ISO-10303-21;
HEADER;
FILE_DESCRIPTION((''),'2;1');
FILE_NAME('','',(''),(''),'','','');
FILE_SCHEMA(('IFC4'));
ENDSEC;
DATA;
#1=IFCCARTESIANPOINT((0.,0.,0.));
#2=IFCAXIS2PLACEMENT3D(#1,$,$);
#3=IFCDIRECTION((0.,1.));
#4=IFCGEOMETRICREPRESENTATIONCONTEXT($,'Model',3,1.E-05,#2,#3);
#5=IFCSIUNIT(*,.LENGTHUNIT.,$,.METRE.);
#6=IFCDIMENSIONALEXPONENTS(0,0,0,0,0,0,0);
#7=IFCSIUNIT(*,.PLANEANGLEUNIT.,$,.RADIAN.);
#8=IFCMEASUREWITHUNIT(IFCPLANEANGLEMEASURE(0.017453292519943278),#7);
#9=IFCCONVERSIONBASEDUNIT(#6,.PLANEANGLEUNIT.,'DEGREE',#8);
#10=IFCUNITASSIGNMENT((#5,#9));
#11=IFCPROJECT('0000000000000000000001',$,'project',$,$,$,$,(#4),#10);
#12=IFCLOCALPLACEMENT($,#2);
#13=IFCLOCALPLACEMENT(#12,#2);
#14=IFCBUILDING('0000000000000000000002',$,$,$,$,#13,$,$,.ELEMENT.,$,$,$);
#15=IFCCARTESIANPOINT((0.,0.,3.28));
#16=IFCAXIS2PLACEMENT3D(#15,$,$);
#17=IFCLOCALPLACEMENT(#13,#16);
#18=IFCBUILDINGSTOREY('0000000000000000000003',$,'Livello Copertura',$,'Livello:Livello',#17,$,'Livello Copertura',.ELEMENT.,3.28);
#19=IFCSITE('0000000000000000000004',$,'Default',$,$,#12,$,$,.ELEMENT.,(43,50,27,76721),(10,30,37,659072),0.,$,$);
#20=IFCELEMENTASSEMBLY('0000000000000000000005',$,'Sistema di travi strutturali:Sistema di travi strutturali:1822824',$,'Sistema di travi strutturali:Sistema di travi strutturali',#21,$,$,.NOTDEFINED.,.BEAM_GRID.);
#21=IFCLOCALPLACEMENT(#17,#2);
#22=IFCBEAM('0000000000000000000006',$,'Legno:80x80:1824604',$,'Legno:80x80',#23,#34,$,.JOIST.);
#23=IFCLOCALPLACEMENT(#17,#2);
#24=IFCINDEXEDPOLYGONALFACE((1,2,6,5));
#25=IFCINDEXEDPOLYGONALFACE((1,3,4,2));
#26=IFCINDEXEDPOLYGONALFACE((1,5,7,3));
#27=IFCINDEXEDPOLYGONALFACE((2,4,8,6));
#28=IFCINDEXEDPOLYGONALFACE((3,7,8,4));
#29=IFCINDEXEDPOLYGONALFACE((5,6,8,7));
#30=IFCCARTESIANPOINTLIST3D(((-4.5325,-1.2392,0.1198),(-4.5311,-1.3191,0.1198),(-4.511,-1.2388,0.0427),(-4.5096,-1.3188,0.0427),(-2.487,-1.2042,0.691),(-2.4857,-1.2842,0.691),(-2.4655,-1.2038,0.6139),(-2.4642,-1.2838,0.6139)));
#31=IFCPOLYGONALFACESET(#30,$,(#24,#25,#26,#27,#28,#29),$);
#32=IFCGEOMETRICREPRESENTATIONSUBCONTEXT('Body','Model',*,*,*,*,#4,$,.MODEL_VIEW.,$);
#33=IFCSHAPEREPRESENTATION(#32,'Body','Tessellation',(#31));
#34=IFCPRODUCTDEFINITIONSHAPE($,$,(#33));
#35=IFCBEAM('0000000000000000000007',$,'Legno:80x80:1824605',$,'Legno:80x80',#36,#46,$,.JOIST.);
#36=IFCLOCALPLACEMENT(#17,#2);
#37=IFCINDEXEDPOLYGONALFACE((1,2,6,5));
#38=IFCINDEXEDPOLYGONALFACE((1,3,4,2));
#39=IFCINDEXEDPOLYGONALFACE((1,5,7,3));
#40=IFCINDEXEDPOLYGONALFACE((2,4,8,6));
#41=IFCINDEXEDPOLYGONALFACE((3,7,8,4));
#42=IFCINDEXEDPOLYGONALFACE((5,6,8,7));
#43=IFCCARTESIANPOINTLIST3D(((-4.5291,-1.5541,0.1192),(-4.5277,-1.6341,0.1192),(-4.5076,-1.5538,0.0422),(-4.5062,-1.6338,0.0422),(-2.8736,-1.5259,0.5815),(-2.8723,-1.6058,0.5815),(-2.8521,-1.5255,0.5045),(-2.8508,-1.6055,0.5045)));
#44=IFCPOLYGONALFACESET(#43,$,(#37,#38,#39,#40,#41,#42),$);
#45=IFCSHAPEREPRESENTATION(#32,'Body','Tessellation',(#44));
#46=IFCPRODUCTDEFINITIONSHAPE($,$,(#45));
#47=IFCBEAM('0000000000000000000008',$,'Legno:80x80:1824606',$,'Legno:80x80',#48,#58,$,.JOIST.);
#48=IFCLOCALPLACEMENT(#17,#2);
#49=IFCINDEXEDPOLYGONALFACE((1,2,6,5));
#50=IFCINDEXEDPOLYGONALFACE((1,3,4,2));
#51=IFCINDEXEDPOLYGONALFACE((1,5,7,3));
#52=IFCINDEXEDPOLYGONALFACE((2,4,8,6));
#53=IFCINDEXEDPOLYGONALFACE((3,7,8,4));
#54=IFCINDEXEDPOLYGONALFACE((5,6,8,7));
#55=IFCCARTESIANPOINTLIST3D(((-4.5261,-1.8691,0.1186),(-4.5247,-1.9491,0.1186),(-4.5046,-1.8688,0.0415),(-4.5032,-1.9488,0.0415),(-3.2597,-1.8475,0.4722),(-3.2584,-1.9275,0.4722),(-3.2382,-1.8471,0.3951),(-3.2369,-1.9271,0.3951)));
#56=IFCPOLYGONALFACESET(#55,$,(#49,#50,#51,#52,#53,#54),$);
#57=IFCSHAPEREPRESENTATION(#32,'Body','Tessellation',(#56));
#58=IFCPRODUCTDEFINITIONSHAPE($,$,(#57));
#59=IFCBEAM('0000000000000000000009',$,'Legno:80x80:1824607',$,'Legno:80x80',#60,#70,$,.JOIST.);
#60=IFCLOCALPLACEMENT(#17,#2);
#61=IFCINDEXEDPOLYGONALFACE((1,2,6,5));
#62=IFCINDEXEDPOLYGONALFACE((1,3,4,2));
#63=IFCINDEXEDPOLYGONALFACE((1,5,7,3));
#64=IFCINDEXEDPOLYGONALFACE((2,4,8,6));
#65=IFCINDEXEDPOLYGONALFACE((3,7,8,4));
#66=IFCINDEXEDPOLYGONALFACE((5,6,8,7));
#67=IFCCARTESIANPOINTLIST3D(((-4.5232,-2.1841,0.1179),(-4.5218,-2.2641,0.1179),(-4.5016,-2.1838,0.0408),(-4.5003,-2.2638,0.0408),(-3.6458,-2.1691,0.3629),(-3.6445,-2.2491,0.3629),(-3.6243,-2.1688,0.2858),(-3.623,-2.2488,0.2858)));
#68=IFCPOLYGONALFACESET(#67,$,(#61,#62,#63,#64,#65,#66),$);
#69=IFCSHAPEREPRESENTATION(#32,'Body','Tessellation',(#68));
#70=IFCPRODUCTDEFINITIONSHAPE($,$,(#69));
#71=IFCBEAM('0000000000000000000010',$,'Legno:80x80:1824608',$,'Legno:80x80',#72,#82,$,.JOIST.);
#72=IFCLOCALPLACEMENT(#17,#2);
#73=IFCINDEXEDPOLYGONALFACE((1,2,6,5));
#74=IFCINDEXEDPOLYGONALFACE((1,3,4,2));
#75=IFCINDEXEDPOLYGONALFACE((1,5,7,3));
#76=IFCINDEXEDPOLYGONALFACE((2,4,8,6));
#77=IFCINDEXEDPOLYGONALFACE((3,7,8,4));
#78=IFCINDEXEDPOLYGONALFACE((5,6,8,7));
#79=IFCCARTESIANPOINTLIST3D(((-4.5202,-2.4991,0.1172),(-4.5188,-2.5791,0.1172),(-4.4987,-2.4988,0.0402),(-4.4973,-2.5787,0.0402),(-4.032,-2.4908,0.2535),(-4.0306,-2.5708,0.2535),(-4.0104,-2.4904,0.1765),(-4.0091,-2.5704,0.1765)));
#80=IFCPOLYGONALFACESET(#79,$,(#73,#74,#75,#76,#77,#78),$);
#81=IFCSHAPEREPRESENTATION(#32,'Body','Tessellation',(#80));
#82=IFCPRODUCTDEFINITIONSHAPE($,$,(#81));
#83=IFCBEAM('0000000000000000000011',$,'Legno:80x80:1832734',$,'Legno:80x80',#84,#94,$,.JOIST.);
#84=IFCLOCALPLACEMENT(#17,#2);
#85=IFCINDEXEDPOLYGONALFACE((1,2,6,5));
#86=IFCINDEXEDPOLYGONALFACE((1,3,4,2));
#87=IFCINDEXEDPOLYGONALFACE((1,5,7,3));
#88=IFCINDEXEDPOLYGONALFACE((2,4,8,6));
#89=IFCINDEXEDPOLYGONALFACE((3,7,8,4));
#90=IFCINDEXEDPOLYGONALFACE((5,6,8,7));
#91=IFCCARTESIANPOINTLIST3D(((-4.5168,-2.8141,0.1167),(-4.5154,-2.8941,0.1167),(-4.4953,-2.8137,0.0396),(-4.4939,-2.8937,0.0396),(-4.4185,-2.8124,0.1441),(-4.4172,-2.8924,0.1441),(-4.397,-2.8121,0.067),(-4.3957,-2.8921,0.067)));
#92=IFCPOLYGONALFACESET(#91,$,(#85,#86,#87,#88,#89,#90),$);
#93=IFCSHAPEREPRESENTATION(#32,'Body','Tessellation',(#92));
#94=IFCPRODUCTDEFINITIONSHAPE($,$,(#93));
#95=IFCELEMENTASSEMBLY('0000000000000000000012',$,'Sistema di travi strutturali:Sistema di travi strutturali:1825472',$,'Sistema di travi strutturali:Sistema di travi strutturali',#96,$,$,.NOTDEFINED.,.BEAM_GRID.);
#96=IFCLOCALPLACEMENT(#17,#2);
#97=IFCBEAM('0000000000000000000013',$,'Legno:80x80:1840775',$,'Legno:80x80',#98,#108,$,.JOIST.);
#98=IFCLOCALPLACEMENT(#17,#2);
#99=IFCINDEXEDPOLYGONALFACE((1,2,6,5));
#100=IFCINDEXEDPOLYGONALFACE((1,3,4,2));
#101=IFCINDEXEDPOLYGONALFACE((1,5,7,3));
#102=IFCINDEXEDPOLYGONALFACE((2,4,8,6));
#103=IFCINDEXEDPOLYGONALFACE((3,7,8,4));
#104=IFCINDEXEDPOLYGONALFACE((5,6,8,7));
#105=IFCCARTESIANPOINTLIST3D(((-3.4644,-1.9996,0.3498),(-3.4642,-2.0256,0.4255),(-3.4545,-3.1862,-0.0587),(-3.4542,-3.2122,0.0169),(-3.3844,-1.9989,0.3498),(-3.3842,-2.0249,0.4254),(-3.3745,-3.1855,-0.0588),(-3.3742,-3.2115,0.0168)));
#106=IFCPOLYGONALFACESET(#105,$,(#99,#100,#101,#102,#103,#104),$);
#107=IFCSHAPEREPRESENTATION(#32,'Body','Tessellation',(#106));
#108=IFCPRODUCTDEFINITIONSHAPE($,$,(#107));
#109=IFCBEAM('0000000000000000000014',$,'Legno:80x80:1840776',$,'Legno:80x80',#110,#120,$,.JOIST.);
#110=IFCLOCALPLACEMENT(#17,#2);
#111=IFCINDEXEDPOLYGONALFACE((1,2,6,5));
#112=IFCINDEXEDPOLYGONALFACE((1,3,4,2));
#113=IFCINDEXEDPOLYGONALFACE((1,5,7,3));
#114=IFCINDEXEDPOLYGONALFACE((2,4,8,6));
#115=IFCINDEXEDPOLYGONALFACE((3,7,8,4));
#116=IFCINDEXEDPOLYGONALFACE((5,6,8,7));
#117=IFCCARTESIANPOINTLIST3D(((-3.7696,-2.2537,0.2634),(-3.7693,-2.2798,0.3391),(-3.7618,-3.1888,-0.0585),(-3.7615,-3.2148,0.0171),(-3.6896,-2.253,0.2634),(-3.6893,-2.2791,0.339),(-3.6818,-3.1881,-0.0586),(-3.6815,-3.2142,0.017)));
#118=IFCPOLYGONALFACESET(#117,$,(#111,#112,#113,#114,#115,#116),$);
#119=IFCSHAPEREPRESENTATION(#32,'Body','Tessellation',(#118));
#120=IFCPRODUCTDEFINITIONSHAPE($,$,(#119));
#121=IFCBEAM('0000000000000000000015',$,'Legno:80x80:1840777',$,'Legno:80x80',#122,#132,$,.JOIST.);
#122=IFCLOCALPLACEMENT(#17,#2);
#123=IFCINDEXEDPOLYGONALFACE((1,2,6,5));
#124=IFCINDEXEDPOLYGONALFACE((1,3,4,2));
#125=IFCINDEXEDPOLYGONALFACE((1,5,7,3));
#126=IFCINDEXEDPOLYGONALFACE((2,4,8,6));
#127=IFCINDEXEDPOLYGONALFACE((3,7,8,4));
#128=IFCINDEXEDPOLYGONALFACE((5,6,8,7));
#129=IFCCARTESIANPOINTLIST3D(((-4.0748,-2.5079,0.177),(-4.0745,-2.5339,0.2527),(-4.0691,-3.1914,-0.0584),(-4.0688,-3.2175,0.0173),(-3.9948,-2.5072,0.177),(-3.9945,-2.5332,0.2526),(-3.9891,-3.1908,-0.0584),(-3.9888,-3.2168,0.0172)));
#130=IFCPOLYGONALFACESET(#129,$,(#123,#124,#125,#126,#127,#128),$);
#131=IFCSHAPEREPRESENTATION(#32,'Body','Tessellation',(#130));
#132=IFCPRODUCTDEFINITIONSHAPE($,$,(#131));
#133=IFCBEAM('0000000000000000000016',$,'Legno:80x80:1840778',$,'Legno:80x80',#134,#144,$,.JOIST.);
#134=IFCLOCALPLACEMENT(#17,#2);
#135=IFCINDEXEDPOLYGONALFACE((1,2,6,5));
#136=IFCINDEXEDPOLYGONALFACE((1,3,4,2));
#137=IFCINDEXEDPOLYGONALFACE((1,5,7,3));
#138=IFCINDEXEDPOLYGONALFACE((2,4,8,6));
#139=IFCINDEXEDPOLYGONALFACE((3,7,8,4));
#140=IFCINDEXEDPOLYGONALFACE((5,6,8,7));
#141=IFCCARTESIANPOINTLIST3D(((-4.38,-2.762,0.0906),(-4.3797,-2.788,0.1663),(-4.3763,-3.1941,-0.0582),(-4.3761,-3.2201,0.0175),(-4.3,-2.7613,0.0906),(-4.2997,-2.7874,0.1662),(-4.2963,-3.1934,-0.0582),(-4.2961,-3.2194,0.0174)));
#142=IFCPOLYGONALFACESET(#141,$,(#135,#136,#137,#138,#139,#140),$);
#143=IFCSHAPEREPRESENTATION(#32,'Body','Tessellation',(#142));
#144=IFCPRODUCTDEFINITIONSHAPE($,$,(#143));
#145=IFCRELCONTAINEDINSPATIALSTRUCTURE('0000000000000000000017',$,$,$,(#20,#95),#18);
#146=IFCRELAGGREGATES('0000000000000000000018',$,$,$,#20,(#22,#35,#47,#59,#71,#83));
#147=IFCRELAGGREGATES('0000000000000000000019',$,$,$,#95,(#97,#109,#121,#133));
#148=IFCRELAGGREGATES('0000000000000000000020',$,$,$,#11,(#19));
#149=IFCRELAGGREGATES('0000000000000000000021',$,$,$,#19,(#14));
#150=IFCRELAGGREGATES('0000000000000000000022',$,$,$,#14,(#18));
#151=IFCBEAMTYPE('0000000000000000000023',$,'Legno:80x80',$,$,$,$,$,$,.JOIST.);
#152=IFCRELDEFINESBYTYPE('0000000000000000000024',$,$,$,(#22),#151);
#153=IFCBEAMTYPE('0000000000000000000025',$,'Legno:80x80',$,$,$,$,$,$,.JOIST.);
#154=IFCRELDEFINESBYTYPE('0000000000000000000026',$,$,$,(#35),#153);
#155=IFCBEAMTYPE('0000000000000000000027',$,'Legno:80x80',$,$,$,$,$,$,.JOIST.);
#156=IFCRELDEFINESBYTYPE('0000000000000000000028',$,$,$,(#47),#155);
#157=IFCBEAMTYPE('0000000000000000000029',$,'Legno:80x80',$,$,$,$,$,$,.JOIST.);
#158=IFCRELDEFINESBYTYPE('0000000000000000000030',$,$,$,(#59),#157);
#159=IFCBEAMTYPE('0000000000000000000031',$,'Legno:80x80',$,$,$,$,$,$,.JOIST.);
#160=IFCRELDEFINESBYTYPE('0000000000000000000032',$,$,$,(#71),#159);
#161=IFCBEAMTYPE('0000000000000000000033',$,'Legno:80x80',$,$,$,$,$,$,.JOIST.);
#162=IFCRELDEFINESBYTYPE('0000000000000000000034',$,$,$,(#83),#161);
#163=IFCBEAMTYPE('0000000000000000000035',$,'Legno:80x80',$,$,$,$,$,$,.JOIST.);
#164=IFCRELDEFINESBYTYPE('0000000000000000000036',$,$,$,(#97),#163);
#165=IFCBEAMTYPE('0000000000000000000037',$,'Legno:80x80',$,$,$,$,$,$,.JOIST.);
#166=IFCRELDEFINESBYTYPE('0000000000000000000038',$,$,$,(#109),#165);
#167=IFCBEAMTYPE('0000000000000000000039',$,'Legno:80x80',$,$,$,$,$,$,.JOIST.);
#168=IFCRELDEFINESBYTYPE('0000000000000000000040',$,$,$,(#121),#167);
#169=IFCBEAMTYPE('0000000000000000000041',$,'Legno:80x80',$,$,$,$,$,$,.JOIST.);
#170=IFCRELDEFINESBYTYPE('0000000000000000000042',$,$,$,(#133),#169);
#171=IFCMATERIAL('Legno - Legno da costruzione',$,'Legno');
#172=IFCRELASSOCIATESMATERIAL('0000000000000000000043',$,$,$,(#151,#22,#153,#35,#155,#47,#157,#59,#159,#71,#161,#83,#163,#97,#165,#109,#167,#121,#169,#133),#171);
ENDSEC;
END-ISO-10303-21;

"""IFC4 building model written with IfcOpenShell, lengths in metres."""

from ifc_helpers import new_model, entity, si_unit, converted_unit, direction, frame, origin, place, context, subcontext, project, spatial, indexed_curve, outline, extrude, source, transform, mapped, material, type_object, type_shapes, element, aggregate, save


model = new_model("IFC4")

# Units and contexts
model_context = context("Model", 3, precision=1e-05, world=origin(), true_north=direction((0.0, 1.0)))
body_context = subcontext(model_context, "Body", "Model", "MODEL_VIEW")
ifc_project = project(units=[si_unit("LENGTHUNIT", "METRE"), converted_unit("PLANEANGLEUNIT", "DEGREE", entity("IfcPlaneAngleMeasure", 0.017453292519943278), si_unit("PLANEANGLEUNIT", "RADIAN"), dimensions=[0, 0, 0, 0, 0, 0, 0])], contexts=[model_context])

# Site, building, storey
site_placement = place(None, origin())
site = spatial("IfcSite", under=ifc_project, at=site_placement, Name="Default", CompositionType="ELEMENT", RefLatitude=(43, 50, 27, 76721), RefLongitude=(10, 30, 37, 659072), RefElevation=0.0)
building_placement = place(site_placement, origin())
building = spatial("IfcBuilding", under=site, at=building_placement, CompositionType="ELEMENT")
storey_placement = place(building_placement, frame((0.0, 0.0, 3.28)))
storey = spatial("IfcBuildingStorey", under=building, at=storey_placement, Name="Livello Copertura", ObjectType="Livello:Livello", LongName="Livello Copertura", CompositionType="ELEMENT", Elevation=3.28)

# Element assemblies, beams
assembly_1_placement = place(storey_placement, origin())
assembly_1 = element("IfcElementAssembly", 1, at=assembly_1_placement, inside=storey, Name="Sistema di travi strutturali:Sistema di travi strutturali:1822824", ObjectType="Sistema di travi strutturali:Sistema di travi strutturali", AssemblyPlace="NOTDEFINED", PredefinedType="BEAM_GRID")
ifc_material = material(Name="Legno - Legno da costruzione", Category="Legno")
beam_type_1 = type_object("IfcBeamType", Name="Legno:80x80", PredefinedType="JOIST", material=ifc_material)
shared_shape_1 = source(origin(), body_context, "Body", "SweptSolid", [
    extrude(outline(indexed_curve([(-1.062, -0.04), (1.062, -0.04), (1.062, 0.04), (-1.062, 0.04), (-1.062, -0.04)], self_intersect=False)), frame((0.0, 0.0, -0.04), z_axis=(0.0, 0.0, 1.0), x_axis=(-1.0, 0.0, 0.0)), (0.0, 0.0, 1.0), 0.08),
])
type_shapes(beam_type_1, [shared_shape_1])
beam_1_placement = place(assembly_1_placement, frame((-3.4983, -1.2615, 0.3669), z_axis=(-0.268881, -0.004594, 0.963163), x_axis=(0.963022, 0.016456, 0.26892)))
beam_1 = element("IfcBeam", 2, at=beam_1_placement, type_object=beam_type_1, material=ifc_material, Name="Legno:80x80:1824604", ObjectType="Legno:80x80", PredefinedType="JOIST", context=body_context, shape_type="MappedRepresentation", body=[
    mapped(shared_shape_1, transform((0.0, 0.0, 0.0), scale=1.0)),
])
beam_type_2 = type_object("IfcBeamType", Name="Legno:80x80", PredefinedType="JOIST", material=ifc_material)
shared_shape_2 = source(origin(), body_context, "Body", "SweptSolid", [
    extrude(outline(indexed_curve([(-0.8595, -0.04), (0.8595, -0.04), (0.8595, 0.04), (-0.8595, 0.04), (-0.8595, -0.04)], self_intersect=False)), frame((0.0, 0.0, -0.04), z_axis=(0.0, 0.0, 1.0), x_axis=(-1.0, 0.0, 0.0)), (0.0, 0.0, 1.0), 0.08),
])
type_shapes(beam_type_2, [shared_shape_2])
beam_2_placement = place(assembly_1_placement, frame((-3.6899, -1.5798, 0.3119), z_axis=(-0.268881, -0.004594, 0.963163), x_axis=(0.963022, 0.016456, 0.26892)))
beam_2 = element("IfcBeam", 3, at=beam_2_placement, type_object=beam_type_2, material=ifc_material, Name="Legno:80x80:1824605", ObjectType="Legno:80x80", PredefinedType="JOIST", context=body_context, shape_type="MappedRepresentation", body=[
    mapped(shared_shape_2, transform((0.0, 0.0, 0.0), scale=1.0)),
])
beam_type_3 = type_object("IfcBeamType", Name="Legno:80x80", PredefinedType="JOIST", material=ifc_material)
shared_shape_3 = source(origin(), body_context, "Body", "SweptSolid", [
    extrude(outline(indexed_curve([(-0.6575, -0.04), (0.6575, -0.04), (0.6575, 0.04), (-0.6575, 0.04), (-0.6575, -0.04)], self_intersect=False)), frame((0.0, 0.0, -0.04), z_axis=(0.0, 0.0, 1.0), x_axis=(-1.0, 0.0, 0.0)), (0.0, 0.0, 1.0), 0.08),
])
type_shapes(beam_type_3, [shared_shape_3])
beam_3_placement = place(assembly_1_placement, frame((-3.8815, -1.8981, 0.2569), z_axis=(-0.268881, -0.004594, 0.963163), x_axis=(0.963022, 0.016456, 0.26892)))
beam_3 = element("IfcBeam", 4, at=beam_3_placement, type_object=beam_type_3, material=ifc_material, Name="Legno:80x80:1824606", ObjectType="Legno:80x80", PredefinedType="JOIST", context=body_context, shape_type="MappedRepresentation", body=[
    mapped(shared_shape_3, transform((0.0, 0.0, 0.0), scale=1.0)),
])
beam_type_4 = type_object("IfcBeamType", Name="Legno:80x80", PredefinedType="JOIST", material=ifc_material)
shared_shape_4 = source(origin(), body_context, "Body", "SweptSolid", [
    extrude(outline(indexed_curve([(-0.4555, -0.04), (0.4555, -0.04), (0.4555, 0.04), (-0.4555, 0.04), (-0.4555, -0.04)], self_intersect=False)), frame((0.0, 0.0, -0.04), z_axis=(0.0, 0.0, 1.0), x_axis=(-1.0, 0.0, 0.0)), (0.0, 0.0, 1.0), 0.08),
])
type_shapes(beam_type_4, [shared_shape_4])
beam_4_placement = place(assembly_1_placement, frame((-4.0731, -2.2164, 0.2019), z_axis=(-0.268881, -0.004594, 0.963163), x_axis=(0.963022, 0.016456, 0.26892)))
beam_4 = element("IfcBeam", 5, at=beam_4_placement, type_object=beam_type_4, material=ifc_material, Name="Legno:80x80:1824607", ObjectType="Legno:80x80", PredefinedType="JOIST", context=body_context, shape_type="MappedRepresentation", body=[
    mapped(shared_shape_4, transform((0.0, 0.0, 0.0), scale=1.0)),
])
beam_type_5 = type_object("IfcBeamType", Name="Legno:80x80", PredefinedType="JOIST", material=ifc_material)
shared_shape_5 = source(origin(), body_context, "Body", "SweptSolid", [
    extrude(outline(indexed_curve([(-0.2535, -0.04), (0.2535, -0.04), (0.2535, 0.04), (-0.2535, 0.04), (-0.2535, -0.04)], self_intersect=False)), frame((0.0, 0.0, -0.04), z_axis=(0.0, 0.0, 1.0), x_axis=(-1.0, 0.0, 0.0)), (0.0, 0.0, 1.0), 0.08),
])
type_shapes(beam_type_5, [shared_shape_5])
beam_5_placement = place(assembly_1_placement, frame((-4.2646, -2.5348, 0.1469), z_axis=(-0.268881, -0.004594, 0.963163), x_axis=(0.963022, 0.016456, 0.26892)))
beam_5 = element("IfcBeam", 6, at=beam_5_placement, type_object=beam_type_5, material=ifc_material, Name="Legno:80x80:1824608", ObjectType="Legno:80x80", PredefinedType="JOIST", context=body_context, shape_type="MappedRepresentation", body=[
    mapped(shared_shape_5, transform((0.0, 0.0, 0.0), scale=1.0)),
])
beam_type_6 = type_object("IfcBeamType", Name="Legno:80x80", PredefinedType="JOIST", material=ifc_material)
shared_shape_6 = source(origin(), body_context, "Body", "SweptSolid", [
    extrude(outline(indexed_curve([(-0.051, -0.04), (0.051, -0.04), (0.051, 0.04), (-0.051, 0.04), (-0.051, -0.04)], self_intersect=False)), frame((0.0, 0.0, -0.04), z_axis=(0.0, 0.0, 1.0), x_axis=(-1.0, 0.0, 0.0)), (0.0, 0.0, 1.0), 0.08),
])
type_shapes(beam_type_6, [shared_shape_6])
beam_6_placement = place(assembly_1_placement, frame((-4.4562, -2.8531, 0.0919), z_axis=(-0.268881, -0.004594, 0.963163), x_axis=(0.963022, 0.016456, 0.26892)))
beam_6 = element("IfcBeam", 7, at=beam_6_placement, type_object=beam_type_6, material=ifc_material, Name="Legno:80x80:1832734", ObjectType="Legno:80x80", PredefinedType="JOIST", context=body_context, shape_type="MappedRepresentation", body=[
    mapped(shared_shape_6, transform((0.0, 0.0, 0.0), scale=1.0)),
])
aggregate(assembly_1, [beam_1, beam_2, beam_3, beam_4, beam_5, beam_6])
assembly_2_placement = place(storey_placement, origin())
assembly_2 = element("IfcElementAssembly", 8, at=assembly_2_placement, inside=storey, Name="Sistema di travi strutturali:Sistema di travi strutturali:1825472", ObjectType="Sistema di travi strutturali:Sistema di travi strutturali", AssemblyPlace="NOTDEFINED", PredefinedType="BEAM_GRID")
beam_type_7 = type_object("IfcBeamType", Name="Legno:80x80", PredefinedType="JOIST", material=ifc_material)
shared_shape_7 = source(origin(), body_context, "Body", "SweptSolid", [
    extrude(outline(indexed_curve([(-0.6275, -0.04), (0.6275, -0.04), (0.6275, 0.04), (-0.6275, 0.04), (-0.6275, -0.04)], self_intersect=False)), frame((0.0, 0.0, -0.04), z_axis=(0.0, 0.0, 1.0), x_axis=(-1.0, 0.0, 0.0)), (0.0, 0.0, 1.0), 0.08),
])
type_shapes(beam_type_7, [shared_shape_7])
beam_7_placement = place(assembly_2_placement, frame((-3.4193, -2.6055, 0.1833), z_axis=(0.003393, -0.32555, 0.945519), x_axis=(-0.007932, 0.945486, 0.325568)))
beam_7 = element("IfcBeam", 9, at=beam_7_placement, type_object=beam_type_7, material=ifc_material, Name="Legno:80x80:1840775", ObjectType="Legno:80x80", PredefinedType="JOIST", context=body_context, shape_type="MappedRepresentation", body=[
    mapped(shared_shape_7, transform((0.0, 0.0, 0.0), scale=1.0)),
])
beam_type_8 = type_object("IfcBeamType", Name="Legno:80x80", PredefinedType="JOIST", material=ifc_material)
shared_shape_8 = source(origin(), body_context, "Body", "SweptSolid", [
    extrude(outline(indexed_curve([(-0.4945, -0.04), (0.4945, -0.04), (0.4945, 0.04), (-0.4945, 0.04), (-0.4945, -0.04)], self_intersect=False)), frame((0.0, 0.0, -0.04), z_axis=(0.0, 0.0, 1.0), x_axis=(-1.0, 0.0, 0.0)), (0.0, 0.0, 1.0), 0.08),
])
type_shapes(beam_type_8, [shared_shape_8])
beam_8_placement = place(assembly_2_placement, frame((-3.7256, -2.7339, 0.1402), z_axis=(0.003393, -0.32555, 0.945519), x_axis=(-0.007932, 0.945486, 0.325568)))
beam_8 = element("IfcBeam", 10, at=beam_8_placement, type_object=beam_type_8, material=ifc_material, Name="Legno:80x80:1840776", ObjectType="Legno:80x80", PredefinedType="JOIST", context=body_context, shape_type="MappedRepresentation", body=[
    mapped(shared_shape_8, transform((0.0, 0.0, 0.0), scale=1.0)),
])
beam_type_9 = type_object("IfcBeamType", Name="Legno:80x80", PredefinedType="JOIST", material=ifc_material)
shared_shape_9 = source(origin(), body_context, "Body", "SweptSolid", [
    extrude(outline(indexed_curve([(-0.3615, -0.04), (0.3615, -0.04), (0.3615, 0.04), (-0.3615, 0.04), (-0.3615, -0.04)], self_intersect=False)), frame((0.0, 0.0, -0.04), z_axis=(0.0, 0.0, 1.0), x_axis=(-1.0, 0.0, 0.0)), (0.0, 0.0, 1.0), 0.08),
])
type_shapes(beam_type_9, [shared_shape_9])
beam_9_placement = place(assembly_2_placement, frame((-4.0318, -2.8623, 0.0971), z_axis=(0.003393, -0.32555, 0.945519), x_axis=(-0.007932, 0.945486, 0.325568)))
beam_9 = element("IfcBeam", 11, at=beam_9_placement, type_object=beam_type_9, material=ifc_material, Name="Legno:80x80:1840777", ObjectType="Legno:80x80", PredefinedType="JOIST", context=body_context, shape_type="MappedRepresentation", body=[
    mapped(shared_shape_9, transform((0.0, 0.0, 0.0), scale=1.0)),
])
beam_type_10 = type_object("IfcBeamType", Name="Legno:80x80", PredefinedType="JOIST", material=ifc_material)
shared_shape_10 = source(origin(), body_context, "Body", "SweptSolid", [
    extrude(outline(indexed_curve([(-0.2285, -0.04), (0.2285, -0.04), (0.2285, 0.04), (-0.2285, 0.04), (-0.2285, -0.04)], self_intersect=False)), frame((0.0, 0.0, -0.04), z_axis=(0.0, 0.0, 1.0), x_axis=(-1.0, 0.0, 0.0)), (0.0, 0.0, 1.0), 0.08),
])
type_shapes(beam_type_10, [shared_shape_10])
beam_10_placement = place(assembly_2_placement, frame((-4.338, -2.9907, 0.054), z_axis=(0.003393, -0.32555, 0.945519), x_axis=(-0.007932, 0.945486, 0.325568)))
beam_10 = element("IfcBeam", 12, at=beam_10_placement, type_object=beam_type_10, material=ifc_material, Name="Legno:80x80:1840778", ObjectType="Legno:80x80", PredefinedType="JOIST", context=body_context, shape_type="MappedRepresentation", body=[
    mapped(shared_shape_10, transform((0.0, 0.0, 0.0), scale=1.0)),
])
aggregate(assembly_2, [beam_7, beam_8, beam_9, beam_10])

save(model, "model.ifc")
